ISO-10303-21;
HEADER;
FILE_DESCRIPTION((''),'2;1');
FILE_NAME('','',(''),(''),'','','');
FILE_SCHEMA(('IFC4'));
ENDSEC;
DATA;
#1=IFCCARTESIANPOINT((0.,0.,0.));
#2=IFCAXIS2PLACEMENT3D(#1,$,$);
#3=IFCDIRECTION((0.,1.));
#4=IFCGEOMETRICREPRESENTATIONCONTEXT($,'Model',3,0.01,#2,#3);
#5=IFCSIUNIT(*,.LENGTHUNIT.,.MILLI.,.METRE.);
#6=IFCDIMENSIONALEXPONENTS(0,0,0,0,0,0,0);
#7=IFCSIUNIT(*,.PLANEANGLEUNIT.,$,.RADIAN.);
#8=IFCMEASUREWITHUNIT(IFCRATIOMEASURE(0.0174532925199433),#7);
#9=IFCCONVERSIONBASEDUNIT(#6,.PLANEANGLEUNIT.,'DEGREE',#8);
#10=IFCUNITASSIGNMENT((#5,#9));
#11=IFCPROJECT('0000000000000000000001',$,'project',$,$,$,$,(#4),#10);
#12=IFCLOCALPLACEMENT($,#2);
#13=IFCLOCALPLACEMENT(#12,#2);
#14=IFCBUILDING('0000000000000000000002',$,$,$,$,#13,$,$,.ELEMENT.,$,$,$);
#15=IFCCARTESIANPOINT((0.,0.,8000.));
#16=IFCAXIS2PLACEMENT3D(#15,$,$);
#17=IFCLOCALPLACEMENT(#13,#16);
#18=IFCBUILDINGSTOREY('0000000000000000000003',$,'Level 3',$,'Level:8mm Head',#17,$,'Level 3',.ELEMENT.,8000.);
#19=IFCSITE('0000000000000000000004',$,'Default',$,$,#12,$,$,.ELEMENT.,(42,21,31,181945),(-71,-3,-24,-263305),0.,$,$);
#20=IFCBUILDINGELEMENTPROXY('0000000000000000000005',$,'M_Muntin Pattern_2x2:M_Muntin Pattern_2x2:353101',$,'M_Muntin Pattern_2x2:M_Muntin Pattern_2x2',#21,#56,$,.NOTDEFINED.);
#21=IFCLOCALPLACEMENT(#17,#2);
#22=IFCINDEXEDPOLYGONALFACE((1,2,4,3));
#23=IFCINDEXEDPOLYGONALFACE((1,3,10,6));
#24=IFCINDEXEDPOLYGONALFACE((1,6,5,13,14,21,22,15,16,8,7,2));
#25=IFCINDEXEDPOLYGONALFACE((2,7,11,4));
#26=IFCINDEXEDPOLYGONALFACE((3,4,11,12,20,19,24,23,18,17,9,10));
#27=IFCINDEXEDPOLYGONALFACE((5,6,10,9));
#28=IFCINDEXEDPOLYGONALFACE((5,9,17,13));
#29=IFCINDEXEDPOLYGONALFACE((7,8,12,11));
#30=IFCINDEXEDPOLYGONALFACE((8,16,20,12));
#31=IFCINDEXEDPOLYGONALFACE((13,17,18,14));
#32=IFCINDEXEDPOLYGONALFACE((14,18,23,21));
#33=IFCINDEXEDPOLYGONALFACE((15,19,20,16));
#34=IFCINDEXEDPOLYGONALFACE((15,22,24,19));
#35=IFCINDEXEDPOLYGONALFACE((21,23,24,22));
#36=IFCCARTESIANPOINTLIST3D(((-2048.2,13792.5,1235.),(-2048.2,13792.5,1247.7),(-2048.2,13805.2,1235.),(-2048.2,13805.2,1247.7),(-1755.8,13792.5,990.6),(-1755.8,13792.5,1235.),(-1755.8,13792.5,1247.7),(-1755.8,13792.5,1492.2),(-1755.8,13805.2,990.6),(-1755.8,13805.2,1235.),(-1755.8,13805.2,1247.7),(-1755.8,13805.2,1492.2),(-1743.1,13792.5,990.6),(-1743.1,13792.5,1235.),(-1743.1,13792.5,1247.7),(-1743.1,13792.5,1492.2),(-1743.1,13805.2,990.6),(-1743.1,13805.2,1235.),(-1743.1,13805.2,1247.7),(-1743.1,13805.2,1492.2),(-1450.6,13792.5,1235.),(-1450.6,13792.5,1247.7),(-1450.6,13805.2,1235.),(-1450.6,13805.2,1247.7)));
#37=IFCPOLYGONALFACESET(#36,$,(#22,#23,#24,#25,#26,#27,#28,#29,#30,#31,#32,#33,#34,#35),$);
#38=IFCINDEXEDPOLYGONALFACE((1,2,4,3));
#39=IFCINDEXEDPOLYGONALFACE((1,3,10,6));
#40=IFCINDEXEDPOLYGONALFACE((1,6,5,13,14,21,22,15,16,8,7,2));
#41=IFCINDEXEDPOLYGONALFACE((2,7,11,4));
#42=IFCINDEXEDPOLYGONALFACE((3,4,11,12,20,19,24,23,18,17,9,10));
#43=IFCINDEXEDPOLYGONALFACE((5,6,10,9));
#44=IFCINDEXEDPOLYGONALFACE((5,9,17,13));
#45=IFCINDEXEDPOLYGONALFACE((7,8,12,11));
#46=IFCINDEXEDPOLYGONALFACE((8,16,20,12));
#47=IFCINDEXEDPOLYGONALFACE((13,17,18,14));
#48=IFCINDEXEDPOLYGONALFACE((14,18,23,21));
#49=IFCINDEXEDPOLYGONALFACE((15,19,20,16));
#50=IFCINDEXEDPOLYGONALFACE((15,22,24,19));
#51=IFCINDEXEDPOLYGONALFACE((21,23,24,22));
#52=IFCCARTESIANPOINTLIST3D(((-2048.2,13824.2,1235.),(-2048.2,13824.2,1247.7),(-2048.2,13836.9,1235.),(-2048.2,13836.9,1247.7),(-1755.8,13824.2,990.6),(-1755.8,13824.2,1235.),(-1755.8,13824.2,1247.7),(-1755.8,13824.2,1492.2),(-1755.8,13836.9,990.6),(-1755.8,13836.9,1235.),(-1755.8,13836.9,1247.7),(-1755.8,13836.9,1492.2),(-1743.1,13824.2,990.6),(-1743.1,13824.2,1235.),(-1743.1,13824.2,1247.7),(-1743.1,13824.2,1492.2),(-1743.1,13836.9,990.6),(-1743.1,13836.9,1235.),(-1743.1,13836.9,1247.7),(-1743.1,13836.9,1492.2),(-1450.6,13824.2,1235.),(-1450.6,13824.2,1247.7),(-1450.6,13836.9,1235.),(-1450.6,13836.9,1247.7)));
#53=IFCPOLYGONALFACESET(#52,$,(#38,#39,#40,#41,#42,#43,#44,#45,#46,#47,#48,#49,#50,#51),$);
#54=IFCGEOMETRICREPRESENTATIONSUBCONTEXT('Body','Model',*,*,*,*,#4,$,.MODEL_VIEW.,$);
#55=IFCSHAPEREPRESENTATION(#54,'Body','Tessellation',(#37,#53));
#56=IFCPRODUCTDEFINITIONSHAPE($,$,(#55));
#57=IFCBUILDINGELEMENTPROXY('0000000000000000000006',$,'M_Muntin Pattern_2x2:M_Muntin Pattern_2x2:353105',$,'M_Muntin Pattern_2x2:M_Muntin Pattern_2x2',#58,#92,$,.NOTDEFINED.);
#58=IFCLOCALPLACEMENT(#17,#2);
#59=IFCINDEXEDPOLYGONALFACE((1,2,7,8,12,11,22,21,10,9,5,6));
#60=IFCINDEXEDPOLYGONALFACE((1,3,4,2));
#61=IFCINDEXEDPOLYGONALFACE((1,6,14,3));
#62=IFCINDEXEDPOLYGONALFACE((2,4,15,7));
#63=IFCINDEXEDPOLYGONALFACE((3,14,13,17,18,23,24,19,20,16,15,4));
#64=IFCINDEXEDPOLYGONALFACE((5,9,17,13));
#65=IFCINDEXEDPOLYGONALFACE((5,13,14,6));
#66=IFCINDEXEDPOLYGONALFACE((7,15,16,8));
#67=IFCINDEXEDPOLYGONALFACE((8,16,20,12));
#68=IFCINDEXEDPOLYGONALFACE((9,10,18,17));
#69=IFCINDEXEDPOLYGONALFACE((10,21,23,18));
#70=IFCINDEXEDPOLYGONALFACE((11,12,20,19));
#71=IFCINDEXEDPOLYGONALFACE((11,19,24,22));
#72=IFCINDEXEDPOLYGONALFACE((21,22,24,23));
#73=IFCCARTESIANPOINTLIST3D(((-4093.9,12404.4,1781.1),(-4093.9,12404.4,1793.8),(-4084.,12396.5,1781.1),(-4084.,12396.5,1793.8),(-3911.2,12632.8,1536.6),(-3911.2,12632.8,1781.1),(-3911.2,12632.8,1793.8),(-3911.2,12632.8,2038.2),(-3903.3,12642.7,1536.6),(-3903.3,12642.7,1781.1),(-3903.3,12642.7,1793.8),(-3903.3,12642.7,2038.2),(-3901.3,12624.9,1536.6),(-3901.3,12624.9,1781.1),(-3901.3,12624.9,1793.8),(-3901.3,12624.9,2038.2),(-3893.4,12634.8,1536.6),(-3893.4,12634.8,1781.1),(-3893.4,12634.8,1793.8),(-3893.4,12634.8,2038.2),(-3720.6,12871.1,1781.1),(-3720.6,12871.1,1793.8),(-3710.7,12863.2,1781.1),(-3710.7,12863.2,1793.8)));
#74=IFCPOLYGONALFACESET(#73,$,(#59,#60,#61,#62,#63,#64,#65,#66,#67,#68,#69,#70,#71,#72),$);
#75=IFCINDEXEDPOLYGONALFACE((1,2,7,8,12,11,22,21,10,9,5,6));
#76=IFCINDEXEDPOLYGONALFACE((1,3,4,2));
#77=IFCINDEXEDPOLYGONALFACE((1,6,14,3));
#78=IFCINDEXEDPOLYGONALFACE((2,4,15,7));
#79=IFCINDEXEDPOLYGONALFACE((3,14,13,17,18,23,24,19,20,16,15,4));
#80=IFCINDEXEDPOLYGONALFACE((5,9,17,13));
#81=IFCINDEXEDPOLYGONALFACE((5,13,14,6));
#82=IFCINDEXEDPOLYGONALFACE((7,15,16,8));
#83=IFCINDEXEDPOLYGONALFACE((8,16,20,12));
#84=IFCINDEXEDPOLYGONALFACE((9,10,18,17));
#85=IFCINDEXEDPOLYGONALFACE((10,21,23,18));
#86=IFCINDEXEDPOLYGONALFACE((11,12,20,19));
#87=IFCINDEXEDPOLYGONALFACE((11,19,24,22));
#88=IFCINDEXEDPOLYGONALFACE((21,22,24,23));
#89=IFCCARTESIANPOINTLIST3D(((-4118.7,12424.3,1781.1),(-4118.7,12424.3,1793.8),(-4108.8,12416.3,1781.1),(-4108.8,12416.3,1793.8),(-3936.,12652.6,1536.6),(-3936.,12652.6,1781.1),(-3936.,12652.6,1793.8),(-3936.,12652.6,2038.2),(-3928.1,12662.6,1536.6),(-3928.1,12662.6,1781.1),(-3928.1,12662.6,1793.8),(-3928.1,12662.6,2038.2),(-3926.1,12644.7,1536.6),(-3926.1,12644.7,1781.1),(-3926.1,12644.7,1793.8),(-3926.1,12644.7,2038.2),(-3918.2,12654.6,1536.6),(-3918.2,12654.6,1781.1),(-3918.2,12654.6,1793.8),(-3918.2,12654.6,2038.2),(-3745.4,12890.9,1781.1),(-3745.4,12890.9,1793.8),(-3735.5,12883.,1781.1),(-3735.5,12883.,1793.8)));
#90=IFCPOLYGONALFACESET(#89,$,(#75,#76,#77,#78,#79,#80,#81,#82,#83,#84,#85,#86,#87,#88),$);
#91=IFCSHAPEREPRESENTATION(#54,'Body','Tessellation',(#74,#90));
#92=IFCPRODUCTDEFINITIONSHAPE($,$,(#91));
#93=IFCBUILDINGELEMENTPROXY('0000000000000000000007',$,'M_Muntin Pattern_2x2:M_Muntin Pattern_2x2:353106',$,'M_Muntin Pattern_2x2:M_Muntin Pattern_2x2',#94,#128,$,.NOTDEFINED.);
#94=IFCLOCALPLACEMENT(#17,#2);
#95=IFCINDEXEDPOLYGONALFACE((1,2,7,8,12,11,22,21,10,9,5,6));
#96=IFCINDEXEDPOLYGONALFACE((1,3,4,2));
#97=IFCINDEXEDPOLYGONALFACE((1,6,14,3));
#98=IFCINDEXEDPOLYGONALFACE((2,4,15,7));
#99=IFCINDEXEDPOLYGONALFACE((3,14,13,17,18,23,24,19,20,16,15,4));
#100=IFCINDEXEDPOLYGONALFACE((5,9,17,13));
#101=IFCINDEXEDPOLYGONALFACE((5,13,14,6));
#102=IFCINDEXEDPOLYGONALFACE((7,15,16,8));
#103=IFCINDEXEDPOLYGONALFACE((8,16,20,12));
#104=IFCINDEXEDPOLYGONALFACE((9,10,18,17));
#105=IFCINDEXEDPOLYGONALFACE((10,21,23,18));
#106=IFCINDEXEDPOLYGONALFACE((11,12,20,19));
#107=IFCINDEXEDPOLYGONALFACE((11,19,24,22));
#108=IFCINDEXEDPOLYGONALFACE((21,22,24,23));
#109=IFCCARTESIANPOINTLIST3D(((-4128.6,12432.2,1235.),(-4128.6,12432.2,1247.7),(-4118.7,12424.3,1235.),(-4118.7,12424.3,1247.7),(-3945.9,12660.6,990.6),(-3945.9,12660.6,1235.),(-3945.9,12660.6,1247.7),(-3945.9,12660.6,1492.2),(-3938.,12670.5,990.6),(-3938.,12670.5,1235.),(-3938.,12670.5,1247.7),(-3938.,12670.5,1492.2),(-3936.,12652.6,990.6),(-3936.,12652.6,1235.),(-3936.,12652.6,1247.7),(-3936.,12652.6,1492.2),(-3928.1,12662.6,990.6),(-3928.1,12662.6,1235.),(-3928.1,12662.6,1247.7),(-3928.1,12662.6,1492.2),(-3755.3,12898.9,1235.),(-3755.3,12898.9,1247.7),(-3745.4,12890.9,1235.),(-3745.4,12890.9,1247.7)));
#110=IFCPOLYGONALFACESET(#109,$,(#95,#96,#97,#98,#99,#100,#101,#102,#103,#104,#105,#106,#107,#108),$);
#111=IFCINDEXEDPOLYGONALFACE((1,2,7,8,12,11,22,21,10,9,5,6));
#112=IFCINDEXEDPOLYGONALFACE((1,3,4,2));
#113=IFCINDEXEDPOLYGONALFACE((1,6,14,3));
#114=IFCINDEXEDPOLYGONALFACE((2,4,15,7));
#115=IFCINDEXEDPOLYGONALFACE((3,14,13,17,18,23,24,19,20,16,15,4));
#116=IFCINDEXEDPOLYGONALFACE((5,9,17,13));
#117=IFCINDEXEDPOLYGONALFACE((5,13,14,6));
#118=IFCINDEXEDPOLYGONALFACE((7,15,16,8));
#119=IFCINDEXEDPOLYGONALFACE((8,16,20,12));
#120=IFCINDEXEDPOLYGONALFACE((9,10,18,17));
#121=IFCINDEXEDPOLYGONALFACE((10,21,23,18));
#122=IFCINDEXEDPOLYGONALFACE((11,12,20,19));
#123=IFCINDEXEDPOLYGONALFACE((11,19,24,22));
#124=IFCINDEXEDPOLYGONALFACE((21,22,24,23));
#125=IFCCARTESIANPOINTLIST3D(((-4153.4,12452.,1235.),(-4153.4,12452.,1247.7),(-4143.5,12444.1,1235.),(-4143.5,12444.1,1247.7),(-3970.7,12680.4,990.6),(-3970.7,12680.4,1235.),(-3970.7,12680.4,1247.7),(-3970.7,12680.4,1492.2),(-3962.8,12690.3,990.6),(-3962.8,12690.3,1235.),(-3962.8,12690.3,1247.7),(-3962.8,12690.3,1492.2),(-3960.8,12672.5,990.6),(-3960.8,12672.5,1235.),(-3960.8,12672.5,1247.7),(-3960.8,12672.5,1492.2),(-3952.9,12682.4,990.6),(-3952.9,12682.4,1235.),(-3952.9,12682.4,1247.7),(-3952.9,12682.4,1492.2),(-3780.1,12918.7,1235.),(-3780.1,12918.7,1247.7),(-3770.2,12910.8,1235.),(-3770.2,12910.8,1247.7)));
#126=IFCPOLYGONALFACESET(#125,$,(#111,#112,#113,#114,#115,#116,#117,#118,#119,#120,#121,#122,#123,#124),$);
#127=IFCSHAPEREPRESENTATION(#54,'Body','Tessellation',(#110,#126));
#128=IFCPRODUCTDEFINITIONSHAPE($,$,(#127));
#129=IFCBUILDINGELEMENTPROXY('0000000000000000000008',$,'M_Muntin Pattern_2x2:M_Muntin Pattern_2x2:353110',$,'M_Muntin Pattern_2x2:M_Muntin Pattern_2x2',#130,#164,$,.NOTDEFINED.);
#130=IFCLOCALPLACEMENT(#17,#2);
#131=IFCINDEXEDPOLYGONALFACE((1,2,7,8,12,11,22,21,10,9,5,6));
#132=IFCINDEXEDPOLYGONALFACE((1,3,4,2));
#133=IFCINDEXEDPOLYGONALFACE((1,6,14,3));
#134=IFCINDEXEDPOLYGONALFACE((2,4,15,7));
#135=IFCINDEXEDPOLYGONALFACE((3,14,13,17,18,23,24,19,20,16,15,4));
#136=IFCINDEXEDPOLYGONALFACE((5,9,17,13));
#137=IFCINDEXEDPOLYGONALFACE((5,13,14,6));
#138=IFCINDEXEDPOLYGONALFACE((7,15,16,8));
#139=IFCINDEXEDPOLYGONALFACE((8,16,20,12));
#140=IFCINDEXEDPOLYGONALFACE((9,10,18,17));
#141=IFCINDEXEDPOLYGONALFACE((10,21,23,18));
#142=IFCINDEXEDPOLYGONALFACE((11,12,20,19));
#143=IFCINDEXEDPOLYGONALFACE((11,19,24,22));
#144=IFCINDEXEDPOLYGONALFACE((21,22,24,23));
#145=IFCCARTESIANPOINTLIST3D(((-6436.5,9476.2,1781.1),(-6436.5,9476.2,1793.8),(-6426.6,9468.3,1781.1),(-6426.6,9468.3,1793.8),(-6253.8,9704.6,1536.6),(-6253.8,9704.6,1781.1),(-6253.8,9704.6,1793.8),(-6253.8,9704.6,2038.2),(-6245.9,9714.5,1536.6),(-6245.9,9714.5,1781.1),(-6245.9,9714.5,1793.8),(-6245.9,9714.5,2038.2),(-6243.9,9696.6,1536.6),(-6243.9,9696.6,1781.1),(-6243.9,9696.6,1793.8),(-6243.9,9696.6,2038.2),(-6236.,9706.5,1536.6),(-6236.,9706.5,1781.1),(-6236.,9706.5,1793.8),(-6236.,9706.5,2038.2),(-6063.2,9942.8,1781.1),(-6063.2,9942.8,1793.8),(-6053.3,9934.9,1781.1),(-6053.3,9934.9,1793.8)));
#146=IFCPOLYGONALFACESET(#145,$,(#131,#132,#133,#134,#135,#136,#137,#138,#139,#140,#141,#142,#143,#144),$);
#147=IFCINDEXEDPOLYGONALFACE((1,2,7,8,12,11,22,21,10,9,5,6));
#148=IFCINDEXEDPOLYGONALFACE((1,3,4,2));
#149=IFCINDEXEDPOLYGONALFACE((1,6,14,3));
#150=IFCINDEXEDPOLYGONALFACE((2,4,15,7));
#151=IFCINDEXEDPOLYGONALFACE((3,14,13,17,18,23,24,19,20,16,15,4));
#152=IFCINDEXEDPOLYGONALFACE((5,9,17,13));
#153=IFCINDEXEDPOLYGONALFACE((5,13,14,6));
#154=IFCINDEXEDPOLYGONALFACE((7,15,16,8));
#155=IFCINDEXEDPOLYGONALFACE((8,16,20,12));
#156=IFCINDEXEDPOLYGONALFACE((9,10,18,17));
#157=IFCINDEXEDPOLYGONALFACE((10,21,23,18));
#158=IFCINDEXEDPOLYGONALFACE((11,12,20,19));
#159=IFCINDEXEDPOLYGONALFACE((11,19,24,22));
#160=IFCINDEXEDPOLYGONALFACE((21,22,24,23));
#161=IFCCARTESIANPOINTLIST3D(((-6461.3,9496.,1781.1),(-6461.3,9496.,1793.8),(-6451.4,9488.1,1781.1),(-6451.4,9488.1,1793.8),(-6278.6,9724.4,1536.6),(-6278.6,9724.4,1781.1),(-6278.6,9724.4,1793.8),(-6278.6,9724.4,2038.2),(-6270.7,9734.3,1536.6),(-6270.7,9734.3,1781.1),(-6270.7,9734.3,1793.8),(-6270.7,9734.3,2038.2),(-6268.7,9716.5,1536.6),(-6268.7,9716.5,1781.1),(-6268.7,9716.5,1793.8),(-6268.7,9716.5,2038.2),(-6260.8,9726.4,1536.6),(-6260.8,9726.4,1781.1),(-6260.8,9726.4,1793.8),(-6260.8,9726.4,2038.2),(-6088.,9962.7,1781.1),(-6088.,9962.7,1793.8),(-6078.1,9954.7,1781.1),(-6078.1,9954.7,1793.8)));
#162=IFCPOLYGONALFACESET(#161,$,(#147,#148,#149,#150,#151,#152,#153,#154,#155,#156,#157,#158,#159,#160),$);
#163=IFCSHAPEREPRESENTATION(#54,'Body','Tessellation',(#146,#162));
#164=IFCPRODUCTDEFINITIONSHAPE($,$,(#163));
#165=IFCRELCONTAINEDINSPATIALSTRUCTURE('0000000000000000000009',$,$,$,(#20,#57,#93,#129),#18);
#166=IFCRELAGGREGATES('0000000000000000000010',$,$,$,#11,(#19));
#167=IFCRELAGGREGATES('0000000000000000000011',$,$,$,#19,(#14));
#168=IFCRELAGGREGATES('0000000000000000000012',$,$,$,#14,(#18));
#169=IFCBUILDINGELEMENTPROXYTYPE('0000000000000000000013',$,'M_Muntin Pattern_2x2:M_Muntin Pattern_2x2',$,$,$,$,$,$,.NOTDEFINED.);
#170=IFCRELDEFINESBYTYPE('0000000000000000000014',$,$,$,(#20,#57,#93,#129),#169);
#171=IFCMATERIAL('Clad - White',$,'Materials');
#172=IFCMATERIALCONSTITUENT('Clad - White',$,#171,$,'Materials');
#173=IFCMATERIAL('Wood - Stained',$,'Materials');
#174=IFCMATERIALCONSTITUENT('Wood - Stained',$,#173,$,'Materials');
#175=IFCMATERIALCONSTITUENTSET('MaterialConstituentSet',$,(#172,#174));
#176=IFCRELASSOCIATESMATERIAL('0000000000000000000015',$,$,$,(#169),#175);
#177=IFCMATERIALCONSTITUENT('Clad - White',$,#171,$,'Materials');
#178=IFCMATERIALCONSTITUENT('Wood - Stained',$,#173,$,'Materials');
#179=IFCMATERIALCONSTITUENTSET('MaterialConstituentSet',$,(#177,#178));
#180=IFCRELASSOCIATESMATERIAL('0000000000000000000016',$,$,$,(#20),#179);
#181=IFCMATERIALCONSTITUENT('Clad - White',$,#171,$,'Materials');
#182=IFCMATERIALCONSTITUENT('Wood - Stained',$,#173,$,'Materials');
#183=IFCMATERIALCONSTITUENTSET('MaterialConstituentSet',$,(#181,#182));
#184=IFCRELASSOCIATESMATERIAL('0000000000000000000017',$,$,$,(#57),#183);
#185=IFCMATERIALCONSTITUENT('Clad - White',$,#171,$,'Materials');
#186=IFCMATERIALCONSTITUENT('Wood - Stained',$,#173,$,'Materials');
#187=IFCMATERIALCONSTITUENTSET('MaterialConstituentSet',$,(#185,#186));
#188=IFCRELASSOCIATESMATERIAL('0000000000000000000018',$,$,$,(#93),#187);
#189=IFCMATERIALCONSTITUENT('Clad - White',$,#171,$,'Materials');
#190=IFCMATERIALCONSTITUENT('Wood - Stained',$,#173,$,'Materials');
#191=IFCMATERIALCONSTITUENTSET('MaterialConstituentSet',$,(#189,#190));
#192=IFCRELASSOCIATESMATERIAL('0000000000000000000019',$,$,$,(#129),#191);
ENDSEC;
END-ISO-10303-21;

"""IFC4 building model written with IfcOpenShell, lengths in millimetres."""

from ifc_helpers import new_model, entity, si_unit, converted_unit, direction, frame, origin, place, context, subcontext, project, spatial, polyline, outline, extrude, source, transform, mapped, material, constituent, constituent_set, type_object, type_shapes, element, save


model = new_model("IFC4")

# Units and contexts
model_context = context("Model", 3, precision=0.01, world=origin(), true_north=direction((0.0, 1.0)))
body_context = subcontext(model_context, "Body", "Model", "MODEL_VIEW")
ifc_project = project(units=[si_unit("LENGTHUNIT", "METRE", prefix="MILLI"), converted_unit("PLANEANGLEUNIT", "DEGREE", entity("IfcRatioMeasure", 0.0174532925199433), si_unit("PLANEANGLEUNIT", "RADIAN"), dimensions=[0, 0, 0, 0, 0, 0, 0])], contexts=[model_context])

# Site, building, storey
site_placement = place(None, origin())
site = spatial("IfcSite", under=ifc_project, at=site_placement, Name="Default", CompositionType="ELEMENT", RefLatitude=(42, 21, 31, 181945), RefLongitude=(-71, -3, -24, -263305), RefElevation=0.0)
building_placement = place(site_placement, origin())
building = spatial("IfcBuilding", under=site, at=building_placement, CompositionType="ELEMENT")
storey_placement = place(building_placement, frame((0.0, 0.0, 8000.0)))
storey = spatial("IfcBuildingStorey", under=building, at=storey_placement, Name="Level 3", ObjectType="Level:8mm Head", LongName="Level 3", CompositionType="ELEMENT", Elevation=8000.0)

# Shared definitions
ifc_material_1 = material(Name="Wood - Stained", Category="Materials")

# Building element proxies
ifc_material_2 = material(Name="Clad - White", Category="Materials")
ifc_constituent_1 = constituent(ifc_material_2, Name="Clad - White", Category="Materials")
ifc_constituent_2 = constituent(ifc_material_1, Name="Wood - Stained", Category="Materials")
ifc_constituent_set_1 = constituent_set(constituents=[ifc_constituent_1, ifc_constituent_2], Name="MaterialConstituentSet")
building_element_proxy_type_1 = type_object("IfcBuildingElementProxyType", Name="M_Muntin Pattern_2x2:M_Muntin Pattern_2x2", PredefinedType="NOTDEFINED", material=ifc_constituent_set_1)
shared_shape_1 = source(origin(), body_context, "Body", "SweptSolid", [
    extrude(outline(polyline([(6.4, -6.4), (250.8, -6.4), (250.8, 6.3), (6.4, 6.3), (6.4, 298.8), (-6.3, 298.8), (-6.3, 6.3), (-250.8, 6.3), (-250.8, -6.4), (-6.3, -6.4), (-6.3, -298.8), (6.4, -298.8), (6.4, -6.4)])), frame((0.0, 9.5, 250.8), z_axis=(0.0, 1.0, 0.0), x_axis=(0.0, 0.0, 1.0)), (0.0, 0.0, 1.0), 12.7),
    extrude(outline(polyline([(6.4, -6.4), (250.8, -6.4), (250.8, 6.3), (6.4, 6.3), (6.4, 298.8), (-6.3, 298.8), (-6.3, 6.3), (-250.8, 6.3), (-250.8, -6.4), (-6.3, -6.4), (-6.3, -298.8), (6.4, -298.8), (6.4, -6.4)])), frame((0.0, -22.2, 250.8), z_axis=(0.0, 1.0, 0.0), x_axis=(0.0, 0.0, 1.0)), (0.0, 0.0, 1.0), 12.7),
])
type_shapes(building_element_proxy_type_1, [shared_shape_1])
ifc_constituent_3 = constituent(ifc_material_2, Name="Clad - White", Category="Materials")
ifc_constituent_4 = constituent(ifc_material_1, Name="Wood - Stained", Category="Materials")
ifc_constituent_set_2 = constituent_set(constituents=[ifc_constituent_3, ifc_constituent_4], Name="MaterialConstituentSet")
proxy_1_placement = place(storey_placement, frame((-1749.4, 13814.7, 990.6), z_axis=(0.0, 0.0, 1.0), x_axis=(-1.0, 0.0, 0.0)))
element("IfcBuildingElementProxy", 1, at=proxy_1_placement, inside=storey, type_object=building_element_proxy_type_1, material=ifc_constituent_set_2, Name="M_Muntin Pattern_2x2:M_Muntin Pattern_2x2:353101", ObjectType="M_Muntin Pattern_2x2:M_Muntin Pattern_2x2", PredefinedType="NOTDEFINED", context=body_context, shape_type="MappedRepresentation", body=[
    mapped(shared_shape_1, transform((0.0, 0.0, 0.0), scale=1.0)),
])
ifc_constituent_5 = constituent(ifc_material_2, Name="Clad - White", Category="Materials")
ifc_constituent_6 = constituent(ifc_material_1, Name="Wood - Stained", Category="Materials")
ifc_constituent_set_3 = constituent_set(constituents=[ifc_constituent_5, ifc_constituent_6], Name="MaterialConstituentSet")
proxy_2_placement = place(storey_placement, frame((-3914.7, 12643.7, 1536.6), z_axis=(0.0, 0.0, 1.0), x_axis=(-0.624695, -0.780869, 0.0)))
element("IfcBuildingElementProxy", 2, at=proxy_2_placement, inside=storey, type_object=building_element_proxy_type_1, material=ifc_constituent_set_3, Name="M_Muntin Pattern_2x2:M_Muntin Pattern_2x2:353105", ObjectType="M_Muntin Pattern_2x2:M_Muntin Pattern_2x2", PredefinedType="NOTDEFINED", context=body_context, shape_type="MappedRepresentation", body=[
    mapped(shared_shape_1, transform((0.0, 0.0, 0.0), scale=1.0)),
])
ifc_constituent_7 = constituent(ifc_material_2, Name="Clad - White", Category="Materials")
ifc_constituent_8 = constituent(ifc_material_1, Name="Wood - Stained", Category="Materials")
ifc_constituent_set_4 = constituent_set(constituents=[ifc_constituent_7, ifc_constituent_8], Name="MaterialConstituentSet")
proxy_3_placement = place(storey_placement, frame((-3949.4, 12671.5, 990.6), z_axis=(0.0, 0.0, 1.0), x_axis=(-0.624695, -0.780869, 0.0)))
element("IfcBuildingElementProxy", 3, at=proxy_3_placement, inside=storey, type_object=building_element_proxy_type_1, material=ifc_constituent_set_4, Name="M_Muntin Pattern_2x2:M_Muntin Pattern_2x2:353106", ObjectType="M_Muntin Pattern_2x2:M_Muntin Pattern_2x2", PredefinedType="NOTDEFINED", context=body_context, shape_type="MappedRepresentation", body=[
    mapped(shared_shape_1, transform((0.0, 0.0, 0.0), scale=1.0)),
])
ifc_constituent_9 = constituent(ifc_material_2, Name="Clad - White", Category="Materials")
ifc_constituent_10 = constituent(ifc_material_1, Name="Wood - Stained", Category="Materials")
ifc_constituent_set_5 = constituent_set(constituents=[ifc_constituent_9, ifc_constituent_10], Name="MaterialConstituentSet")
proxy_4_placement = place(storey_placement, frame((-6257.3, 9715.5, 1536.6), z_axis=(0.0, 0.0, 1.0), x_axis=(-0.624695, -0.780869, 0.0)))
element("IfcBuildingElementProxy", 4, at=proxy_4_placement, inside=storey, type_object=building_element_proxy_type_1, material=ifc_constituent_set_5, Name="M_Muntin Pattern_2x2:M_Muntin Pattern_2x2:353110", ObjectType="M_Muntin Pattern_2x2:M_Muntin Pattern_2x2", PredefinedType="NOTDEFINED", context=body_context, shape_type="MappedRepresentation", body=[
    mapped(shared_shape_1, transform((0.0, 0.0, 0.0), scale=1.0)),
])

save(model, "model.ifc")
